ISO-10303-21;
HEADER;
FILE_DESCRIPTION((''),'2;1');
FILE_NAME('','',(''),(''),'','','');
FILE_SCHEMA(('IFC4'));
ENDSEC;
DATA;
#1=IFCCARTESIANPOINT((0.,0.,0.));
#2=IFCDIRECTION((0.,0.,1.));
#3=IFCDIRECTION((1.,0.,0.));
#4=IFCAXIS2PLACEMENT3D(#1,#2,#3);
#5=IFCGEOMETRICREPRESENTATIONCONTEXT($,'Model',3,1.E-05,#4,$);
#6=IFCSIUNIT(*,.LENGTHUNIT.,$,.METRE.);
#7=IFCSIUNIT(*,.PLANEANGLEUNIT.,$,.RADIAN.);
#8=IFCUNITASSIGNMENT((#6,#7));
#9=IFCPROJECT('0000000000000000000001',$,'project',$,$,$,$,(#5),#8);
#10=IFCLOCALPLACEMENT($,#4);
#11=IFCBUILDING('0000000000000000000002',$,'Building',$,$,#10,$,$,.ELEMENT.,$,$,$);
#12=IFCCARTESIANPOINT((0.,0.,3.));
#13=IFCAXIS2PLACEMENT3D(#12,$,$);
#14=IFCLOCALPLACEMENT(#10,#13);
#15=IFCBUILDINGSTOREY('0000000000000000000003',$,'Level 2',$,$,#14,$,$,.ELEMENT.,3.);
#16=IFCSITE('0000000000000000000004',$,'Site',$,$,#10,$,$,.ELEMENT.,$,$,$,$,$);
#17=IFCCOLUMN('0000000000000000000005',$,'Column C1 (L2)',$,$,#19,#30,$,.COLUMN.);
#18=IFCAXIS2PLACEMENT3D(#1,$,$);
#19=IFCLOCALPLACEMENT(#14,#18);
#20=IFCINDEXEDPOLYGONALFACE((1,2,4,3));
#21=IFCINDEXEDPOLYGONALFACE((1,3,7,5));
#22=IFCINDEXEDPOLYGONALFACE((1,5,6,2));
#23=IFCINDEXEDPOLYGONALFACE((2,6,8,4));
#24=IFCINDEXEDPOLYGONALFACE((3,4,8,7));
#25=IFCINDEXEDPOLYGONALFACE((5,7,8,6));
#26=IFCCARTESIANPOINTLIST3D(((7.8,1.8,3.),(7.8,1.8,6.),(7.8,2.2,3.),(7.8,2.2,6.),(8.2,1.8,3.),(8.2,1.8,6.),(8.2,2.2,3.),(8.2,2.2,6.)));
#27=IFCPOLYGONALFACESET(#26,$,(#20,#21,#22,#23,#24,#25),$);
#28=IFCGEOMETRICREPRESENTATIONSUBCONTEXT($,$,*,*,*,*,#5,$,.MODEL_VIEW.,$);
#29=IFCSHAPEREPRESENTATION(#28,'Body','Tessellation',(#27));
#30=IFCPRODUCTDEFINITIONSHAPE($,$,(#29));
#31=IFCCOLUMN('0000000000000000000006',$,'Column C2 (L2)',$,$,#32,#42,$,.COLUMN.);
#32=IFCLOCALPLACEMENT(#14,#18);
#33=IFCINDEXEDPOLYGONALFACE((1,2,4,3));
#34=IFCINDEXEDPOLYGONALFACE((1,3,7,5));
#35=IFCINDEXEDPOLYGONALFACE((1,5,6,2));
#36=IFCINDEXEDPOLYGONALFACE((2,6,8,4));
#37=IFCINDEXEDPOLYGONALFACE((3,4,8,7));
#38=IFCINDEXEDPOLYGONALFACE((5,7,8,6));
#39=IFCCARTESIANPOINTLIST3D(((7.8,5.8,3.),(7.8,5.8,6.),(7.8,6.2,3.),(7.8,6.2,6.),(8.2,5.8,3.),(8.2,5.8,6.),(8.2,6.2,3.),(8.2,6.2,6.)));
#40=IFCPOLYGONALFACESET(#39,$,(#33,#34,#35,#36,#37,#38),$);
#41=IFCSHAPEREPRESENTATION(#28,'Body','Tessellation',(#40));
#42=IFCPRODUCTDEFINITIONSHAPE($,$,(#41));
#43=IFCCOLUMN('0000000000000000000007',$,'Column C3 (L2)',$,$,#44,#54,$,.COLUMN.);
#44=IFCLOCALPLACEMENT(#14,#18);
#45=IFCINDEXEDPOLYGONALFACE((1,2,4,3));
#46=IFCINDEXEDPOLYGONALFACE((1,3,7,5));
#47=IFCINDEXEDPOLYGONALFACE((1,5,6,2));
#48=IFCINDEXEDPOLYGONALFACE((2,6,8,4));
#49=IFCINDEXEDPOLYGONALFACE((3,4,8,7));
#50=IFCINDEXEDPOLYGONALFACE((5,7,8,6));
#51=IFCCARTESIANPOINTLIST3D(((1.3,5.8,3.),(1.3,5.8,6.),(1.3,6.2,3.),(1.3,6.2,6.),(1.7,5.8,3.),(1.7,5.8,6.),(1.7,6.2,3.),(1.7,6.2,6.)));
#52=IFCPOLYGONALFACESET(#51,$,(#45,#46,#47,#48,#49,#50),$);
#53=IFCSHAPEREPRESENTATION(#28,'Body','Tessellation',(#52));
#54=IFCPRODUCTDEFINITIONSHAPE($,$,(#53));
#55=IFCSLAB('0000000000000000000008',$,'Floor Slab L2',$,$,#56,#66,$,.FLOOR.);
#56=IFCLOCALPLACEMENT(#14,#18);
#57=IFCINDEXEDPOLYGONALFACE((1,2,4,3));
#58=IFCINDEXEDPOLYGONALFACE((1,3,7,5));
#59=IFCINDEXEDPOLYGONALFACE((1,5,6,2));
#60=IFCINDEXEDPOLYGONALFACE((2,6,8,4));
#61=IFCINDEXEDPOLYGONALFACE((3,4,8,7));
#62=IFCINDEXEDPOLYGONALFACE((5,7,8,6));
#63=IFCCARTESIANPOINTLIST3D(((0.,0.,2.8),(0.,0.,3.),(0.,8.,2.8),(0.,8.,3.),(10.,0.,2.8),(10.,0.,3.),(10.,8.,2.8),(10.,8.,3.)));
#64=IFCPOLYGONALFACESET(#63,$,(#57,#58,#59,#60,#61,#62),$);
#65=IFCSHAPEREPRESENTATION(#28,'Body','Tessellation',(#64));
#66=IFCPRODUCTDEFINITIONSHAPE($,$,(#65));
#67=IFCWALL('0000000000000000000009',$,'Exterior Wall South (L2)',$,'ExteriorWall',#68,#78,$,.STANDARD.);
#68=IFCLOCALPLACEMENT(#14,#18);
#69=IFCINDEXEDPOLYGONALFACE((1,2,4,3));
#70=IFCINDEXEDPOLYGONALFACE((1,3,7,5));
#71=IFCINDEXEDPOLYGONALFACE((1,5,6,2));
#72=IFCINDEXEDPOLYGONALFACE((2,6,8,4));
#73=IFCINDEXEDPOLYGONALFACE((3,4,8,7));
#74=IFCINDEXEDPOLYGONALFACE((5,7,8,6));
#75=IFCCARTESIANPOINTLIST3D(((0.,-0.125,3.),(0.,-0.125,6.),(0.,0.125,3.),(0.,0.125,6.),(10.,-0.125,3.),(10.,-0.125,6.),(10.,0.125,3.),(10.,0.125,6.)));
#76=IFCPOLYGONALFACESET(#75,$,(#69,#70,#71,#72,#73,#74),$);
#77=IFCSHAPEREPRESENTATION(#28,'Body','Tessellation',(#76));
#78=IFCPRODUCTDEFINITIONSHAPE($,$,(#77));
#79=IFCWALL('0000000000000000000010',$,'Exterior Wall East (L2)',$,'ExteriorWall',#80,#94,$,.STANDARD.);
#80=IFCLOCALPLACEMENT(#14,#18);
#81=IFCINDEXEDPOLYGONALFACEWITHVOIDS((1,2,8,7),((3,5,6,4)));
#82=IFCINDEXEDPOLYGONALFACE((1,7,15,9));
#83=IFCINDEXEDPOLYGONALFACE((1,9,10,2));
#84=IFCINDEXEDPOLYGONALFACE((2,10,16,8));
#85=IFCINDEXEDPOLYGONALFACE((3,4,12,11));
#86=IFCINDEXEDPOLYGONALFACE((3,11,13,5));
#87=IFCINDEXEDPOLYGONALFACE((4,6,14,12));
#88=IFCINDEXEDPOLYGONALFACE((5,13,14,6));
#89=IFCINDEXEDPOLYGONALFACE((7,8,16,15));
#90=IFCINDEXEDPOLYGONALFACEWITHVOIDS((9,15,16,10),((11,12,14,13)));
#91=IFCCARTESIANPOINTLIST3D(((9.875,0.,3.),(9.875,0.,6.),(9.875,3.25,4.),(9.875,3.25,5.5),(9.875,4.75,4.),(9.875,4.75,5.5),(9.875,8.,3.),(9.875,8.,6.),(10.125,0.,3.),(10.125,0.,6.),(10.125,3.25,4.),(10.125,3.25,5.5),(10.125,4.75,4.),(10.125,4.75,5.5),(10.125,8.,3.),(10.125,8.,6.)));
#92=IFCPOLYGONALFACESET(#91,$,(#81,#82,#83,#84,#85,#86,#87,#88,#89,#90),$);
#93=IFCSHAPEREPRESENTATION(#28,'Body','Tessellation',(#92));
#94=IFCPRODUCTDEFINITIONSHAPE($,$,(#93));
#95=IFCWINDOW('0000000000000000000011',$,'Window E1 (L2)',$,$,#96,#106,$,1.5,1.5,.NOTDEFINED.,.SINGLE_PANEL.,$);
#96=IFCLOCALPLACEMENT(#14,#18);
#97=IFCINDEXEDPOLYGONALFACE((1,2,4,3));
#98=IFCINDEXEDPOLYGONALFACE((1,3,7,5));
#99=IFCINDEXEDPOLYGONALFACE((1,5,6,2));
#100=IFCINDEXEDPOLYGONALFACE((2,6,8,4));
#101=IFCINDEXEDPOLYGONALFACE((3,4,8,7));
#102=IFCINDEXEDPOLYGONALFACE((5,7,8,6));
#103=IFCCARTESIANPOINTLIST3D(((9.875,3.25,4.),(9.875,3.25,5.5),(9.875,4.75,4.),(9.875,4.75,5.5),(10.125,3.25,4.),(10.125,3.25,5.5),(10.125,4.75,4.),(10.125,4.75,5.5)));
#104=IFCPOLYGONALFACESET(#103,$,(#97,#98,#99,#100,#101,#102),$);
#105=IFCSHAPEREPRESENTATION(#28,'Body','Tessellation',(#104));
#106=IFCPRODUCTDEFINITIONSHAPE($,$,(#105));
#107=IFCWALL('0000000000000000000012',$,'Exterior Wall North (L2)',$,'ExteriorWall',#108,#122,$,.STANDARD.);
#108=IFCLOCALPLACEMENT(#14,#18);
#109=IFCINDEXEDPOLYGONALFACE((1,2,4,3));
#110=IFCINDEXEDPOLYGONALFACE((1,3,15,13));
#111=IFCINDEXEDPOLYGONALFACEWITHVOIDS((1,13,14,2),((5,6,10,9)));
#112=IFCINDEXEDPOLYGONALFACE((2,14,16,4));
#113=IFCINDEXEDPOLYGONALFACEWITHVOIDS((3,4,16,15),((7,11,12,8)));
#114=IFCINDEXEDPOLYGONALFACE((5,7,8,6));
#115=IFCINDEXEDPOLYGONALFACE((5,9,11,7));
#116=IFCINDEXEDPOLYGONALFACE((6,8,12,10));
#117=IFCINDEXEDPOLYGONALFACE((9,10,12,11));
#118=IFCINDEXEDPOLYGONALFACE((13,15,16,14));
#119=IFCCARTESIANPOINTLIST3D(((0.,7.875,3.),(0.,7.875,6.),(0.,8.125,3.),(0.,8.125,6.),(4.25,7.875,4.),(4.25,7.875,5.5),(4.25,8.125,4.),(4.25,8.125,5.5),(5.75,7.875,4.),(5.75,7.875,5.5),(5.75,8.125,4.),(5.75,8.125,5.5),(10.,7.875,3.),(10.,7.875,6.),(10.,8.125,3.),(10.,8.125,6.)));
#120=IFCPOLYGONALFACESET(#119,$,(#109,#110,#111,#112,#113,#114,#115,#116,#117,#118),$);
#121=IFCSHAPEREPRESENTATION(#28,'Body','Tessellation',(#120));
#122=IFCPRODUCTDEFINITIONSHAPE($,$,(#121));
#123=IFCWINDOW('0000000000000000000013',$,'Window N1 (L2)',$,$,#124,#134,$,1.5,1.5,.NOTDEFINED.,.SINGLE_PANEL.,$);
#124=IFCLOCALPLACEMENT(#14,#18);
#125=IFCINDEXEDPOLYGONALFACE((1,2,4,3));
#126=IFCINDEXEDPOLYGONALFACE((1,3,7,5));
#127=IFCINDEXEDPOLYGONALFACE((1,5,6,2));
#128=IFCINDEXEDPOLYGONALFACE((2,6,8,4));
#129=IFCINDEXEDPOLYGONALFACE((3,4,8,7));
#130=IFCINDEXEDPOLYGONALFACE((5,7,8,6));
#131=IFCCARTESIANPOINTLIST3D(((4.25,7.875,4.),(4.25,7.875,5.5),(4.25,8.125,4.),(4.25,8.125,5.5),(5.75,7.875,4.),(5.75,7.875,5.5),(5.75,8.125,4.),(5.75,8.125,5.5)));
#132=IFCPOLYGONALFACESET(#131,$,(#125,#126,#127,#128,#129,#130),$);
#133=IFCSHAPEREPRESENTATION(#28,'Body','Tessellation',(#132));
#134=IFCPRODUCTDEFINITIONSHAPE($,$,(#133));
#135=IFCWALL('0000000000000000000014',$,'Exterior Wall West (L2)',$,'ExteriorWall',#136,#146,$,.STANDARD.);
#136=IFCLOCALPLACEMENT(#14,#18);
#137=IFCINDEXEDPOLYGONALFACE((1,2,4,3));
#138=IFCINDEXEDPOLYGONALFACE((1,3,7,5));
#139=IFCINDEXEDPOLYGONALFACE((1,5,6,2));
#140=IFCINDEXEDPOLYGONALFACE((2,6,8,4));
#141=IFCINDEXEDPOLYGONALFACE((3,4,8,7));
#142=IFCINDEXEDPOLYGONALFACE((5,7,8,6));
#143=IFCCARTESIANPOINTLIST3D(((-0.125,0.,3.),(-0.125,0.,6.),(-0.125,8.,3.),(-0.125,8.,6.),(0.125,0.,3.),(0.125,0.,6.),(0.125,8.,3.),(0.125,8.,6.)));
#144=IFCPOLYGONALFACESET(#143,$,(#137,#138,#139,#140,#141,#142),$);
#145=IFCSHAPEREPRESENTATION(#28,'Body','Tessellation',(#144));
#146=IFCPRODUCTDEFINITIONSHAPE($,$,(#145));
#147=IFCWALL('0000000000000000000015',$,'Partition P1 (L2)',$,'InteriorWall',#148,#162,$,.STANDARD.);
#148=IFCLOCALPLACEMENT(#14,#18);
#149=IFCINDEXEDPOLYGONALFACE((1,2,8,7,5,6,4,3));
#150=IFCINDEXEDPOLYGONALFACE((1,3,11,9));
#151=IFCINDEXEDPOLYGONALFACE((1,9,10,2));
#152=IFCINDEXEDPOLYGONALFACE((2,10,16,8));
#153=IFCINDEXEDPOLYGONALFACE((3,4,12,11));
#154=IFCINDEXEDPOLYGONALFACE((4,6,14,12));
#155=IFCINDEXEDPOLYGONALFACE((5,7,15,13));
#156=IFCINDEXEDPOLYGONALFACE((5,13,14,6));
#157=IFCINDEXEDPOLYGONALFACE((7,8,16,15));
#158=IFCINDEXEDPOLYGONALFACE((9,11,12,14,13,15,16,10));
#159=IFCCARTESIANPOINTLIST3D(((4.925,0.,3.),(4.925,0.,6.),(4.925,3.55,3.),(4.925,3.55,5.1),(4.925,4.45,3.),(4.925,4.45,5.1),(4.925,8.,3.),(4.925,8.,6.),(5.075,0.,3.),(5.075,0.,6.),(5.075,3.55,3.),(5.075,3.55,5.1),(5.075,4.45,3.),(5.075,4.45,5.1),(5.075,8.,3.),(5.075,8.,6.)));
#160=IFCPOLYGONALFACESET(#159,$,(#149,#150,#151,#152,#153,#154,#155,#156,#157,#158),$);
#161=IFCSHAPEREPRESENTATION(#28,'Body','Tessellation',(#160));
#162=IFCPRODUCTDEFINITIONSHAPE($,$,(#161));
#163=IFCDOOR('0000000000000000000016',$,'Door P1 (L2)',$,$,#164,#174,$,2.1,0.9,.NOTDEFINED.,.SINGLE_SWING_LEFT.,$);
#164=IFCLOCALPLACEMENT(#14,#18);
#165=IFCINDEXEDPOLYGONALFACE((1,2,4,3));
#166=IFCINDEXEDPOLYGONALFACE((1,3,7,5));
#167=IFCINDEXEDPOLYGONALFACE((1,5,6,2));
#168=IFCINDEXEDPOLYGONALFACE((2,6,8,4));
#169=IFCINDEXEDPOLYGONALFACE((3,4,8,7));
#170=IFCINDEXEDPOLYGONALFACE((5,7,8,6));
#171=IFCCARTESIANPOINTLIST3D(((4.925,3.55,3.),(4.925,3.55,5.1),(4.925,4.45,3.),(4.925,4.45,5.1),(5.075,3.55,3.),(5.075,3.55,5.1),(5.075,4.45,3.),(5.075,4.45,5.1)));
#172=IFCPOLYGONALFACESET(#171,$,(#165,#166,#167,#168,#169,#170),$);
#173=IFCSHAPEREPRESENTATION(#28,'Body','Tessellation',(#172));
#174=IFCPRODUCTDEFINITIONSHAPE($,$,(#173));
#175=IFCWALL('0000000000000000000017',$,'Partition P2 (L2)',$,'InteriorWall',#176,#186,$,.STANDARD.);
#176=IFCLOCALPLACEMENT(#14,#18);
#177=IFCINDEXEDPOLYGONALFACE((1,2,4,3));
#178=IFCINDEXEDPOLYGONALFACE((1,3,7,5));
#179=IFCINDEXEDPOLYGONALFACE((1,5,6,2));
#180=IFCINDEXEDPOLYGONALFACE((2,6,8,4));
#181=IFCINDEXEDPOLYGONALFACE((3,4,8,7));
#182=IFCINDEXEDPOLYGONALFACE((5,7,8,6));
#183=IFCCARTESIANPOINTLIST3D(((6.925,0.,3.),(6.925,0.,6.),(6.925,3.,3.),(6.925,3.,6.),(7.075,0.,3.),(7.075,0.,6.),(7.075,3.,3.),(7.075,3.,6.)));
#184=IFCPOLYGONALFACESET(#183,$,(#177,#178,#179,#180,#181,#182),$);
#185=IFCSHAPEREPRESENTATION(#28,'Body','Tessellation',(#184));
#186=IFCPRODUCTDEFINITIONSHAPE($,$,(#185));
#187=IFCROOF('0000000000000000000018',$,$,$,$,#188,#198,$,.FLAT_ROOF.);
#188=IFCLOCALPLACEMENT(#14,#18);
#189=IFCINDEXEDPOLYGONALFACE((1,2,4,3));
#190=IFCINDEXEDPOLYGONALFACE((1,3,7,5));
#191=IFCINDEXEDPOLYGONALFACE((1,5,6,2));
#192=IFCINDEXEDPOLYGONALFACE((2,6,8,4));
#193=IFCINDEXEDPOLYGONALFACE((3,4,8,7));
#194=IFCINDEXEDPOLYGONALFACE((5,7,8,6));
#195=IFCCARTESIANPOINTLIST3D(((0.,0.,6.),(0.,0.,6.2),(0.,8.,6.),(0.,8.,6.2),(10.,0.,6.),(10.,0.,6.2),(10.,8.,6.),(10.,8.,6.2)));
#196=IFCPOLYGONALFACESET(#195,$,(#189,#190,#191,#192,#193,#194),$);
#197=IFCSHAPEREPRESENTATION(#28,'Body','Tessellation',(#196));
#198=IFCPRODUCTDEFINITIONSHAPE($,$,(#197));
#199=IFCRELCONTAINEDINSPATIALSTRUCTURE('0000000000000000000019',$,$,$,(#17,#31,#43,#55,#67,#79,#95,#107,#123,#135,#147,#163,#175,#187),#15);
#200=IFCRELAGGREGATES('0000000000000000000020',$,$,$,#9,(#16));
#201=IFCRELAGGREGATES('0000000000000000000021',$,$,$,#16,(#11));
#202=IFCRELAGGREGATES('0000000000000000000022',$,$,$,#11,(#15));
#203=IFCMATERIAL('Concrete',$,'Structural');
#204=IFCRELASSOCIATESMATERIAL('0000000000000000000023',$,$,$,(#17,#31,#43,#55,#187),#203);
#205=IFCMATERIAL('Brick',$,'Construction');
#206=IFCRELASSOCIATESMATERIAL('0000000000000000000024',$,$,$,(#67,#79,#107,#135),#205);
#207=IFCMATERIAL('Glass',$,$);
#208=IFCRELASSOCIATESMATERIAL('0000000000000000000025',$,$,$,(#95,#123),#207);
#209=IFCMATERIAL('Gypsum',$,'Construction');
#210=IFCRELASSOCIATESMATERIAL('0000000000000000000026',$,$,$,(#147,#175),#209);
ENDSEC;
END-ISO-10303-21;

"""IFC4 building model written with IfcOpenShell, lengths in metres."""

from ifc_helpers import new_model, si_unit, frame, frame_2d, origin, origin_with_axes, origin_2d, place, context, subcontext, project, spatial, rectangle, extrude, material, element, fill, save


model = new_model("IFC4")

# Units and contexts
model_context = context("Model", 3, precision=1e-05, world=origin_with_axes())
sub_context = subcontext(model_context, None, None, "MODEL_VIEW")
ifc_project = project(units=[si_unit("LENGTHUNIT", "METRE"), si_unit("PLANEANGLEUNIT", "RADIAN")], contexts=[model_context])

# Site, building, storey
placement = place(None, origin_with_axes())
site = spatial("IfcSite", under=ifc_project, at=placement, Name="Site", CompositionType="ELEMENT")
building = spatial("IfcBuilding", under=site, at=placement, Name="Building", CompositionType="ELEMENT")
storey_placement = place(placement, frame((0.0, 0.0, 3.0)))
storey = spatial("IfcBuildingStorey", under=building, at=storey_placement, Name="Level 2", CompositionType="ELEMENT", Elevation=3.0)

# Columns
ifc_material_1 = material(Name="Concrete", Category="Structural")
for number, where, name in (
    (1, (8.0, 2.0, 3.0), "Column C1 (L2)"),
    (2, (8.0, 6.0, 3.0), "Column C2 (L2)"),
    (3, (1.5, 6.0, 3.0), "Column C3 (L2)"),
):
    element("IfcColumn", number, at=place(storey_placement, frame(where)), inside=storey, material=ifc_material_1, Name=name, PredefinedType="COLUMN", context=sub_context, shape_type="SweptSolid", body=[
        extrude(rectangle(XDim=0.4, YDim=0.4, at=origin_2d()), origin(), (0.0, 0.0, 1.0), 3.0),
    ])

# Slab
slab_placement = place(storey_placement, frame((0.0, 0.0, 2.8)))
element("IfcSlab", 4, at=slab_placement, inside=storey, material=ifc_material_1, Name="Floor Slab L2", PredefinedType="FLOOR", context=sub_context, shape_type="SweptSolid", body=[
    extrude(rectangle(XDim=10.0, YDim=8.0, at=frame_2d((5.0, 4.0))), origin(), (0.0, 0.0, 1.0), 0.2),
])

# Wall
ifc_material_2 = material(Name="Brick", Category="Construction")
wall_1_placement = place(storey_placement, frame((0.0, 0.0, 3.0), x_axis=(1.0, 0.0, 0.0)))
element("IfcWall", 5, at=wall_1_placement, inside=storey, material=ifc_material_2, Name="Exterior Wall South (L2)", ObjectType="ExteriorWall", PredefinedType="STANDARD", context=sub_context, shape_type="SweptSolid", body=[
    extrude(rectangle(XDim=10.0, YDim=0.25, at=frame_2d((5.0, 0.0))), origin(), (0.0, 0.0, 1.0), 3.0),
])

# Walls, openings, windows
wall_2_placement = place(storey_placement, frame((10.0, 0.0, 3.0), x_axis=(0.0, 1.0, 0.0)))
wall_2 = element("IfcWall", 6, at=wall_2_placement, inside=storey, material=ifc_material_2, Name="Exterior Wall East (L2)", ObjectType="ExteriorWall", PredefinedType="STANDARD", context=sub_context, shape_type="SweptSolid", body=[
    extrude(rectangle(XDim=8.0, YDim=0.25, at=frame_2d((4.0, 0.0))), origin(), (0.0, 0.0, 1.0), 3.0),
])
opening_1_placement = place(wall_2_placement, frame((4.0, 0.175, 1.0), z_axis=(0.0, -1.0, 0.0), x_axis=(1.0, 0.0, 0.0)))
opening_1 = element("IfcOpeningElement", 7, at=opening_1_placement, cuts=wall_2, PredefinedType="OPENING", context=sub_context, shape_type="SweptSolid", body=[
    extrude(rectangle(XDim=1.5, YDim=1.5, at=frame_2d((0.0, 0.75))), origin(), (0.0, 0.0, 1.0), 0.35),
])
ifc_material_3 = material(Name="Glass")
window_1_placement = place(wall_2_placement, frame((4.0, 0.125, 1.0), z_axis=(0.0, -1.0, 0.0), x_axis=(1.0, 0.0, 0.0)))
window_1 = element("IfcWindow", 8, at=window_1_placement, inside=storey, material=ifc_material_3, Name="Window E1 (L2)", OverallHeight=1.5, OverallWidth=1.5, PartitioningType="SINGLE_PANEL", PredefinedType="NOTDEFINED", context=sub_context, shape_type="SweptSolid", body=[
    extrude(rectangle(XDim=1.5, YDim=1.5, at=frame_2d((0.0, 0.75))), origin(), (0.0, 0.0, 1.0), 0.25),
])
fill(opening_1, window_1)
wall_3_placement = place(storey_placement, frame((10.0, 8.0, 3.0), x_axis=(-1.0, 0.0, 0.0)))
wall_3 = element("IfcWall", 9, at=wall_3_placement, inside=storey, material=ifc_material_2, Name="Exterior Wall North (L2)", ObjectType="ExteriorWall", PredefinedType="STANDARD", context=sub_context, shape_type="SweptSolid", body=[
    extrude(rectangle(XDim=10.0, YDim=0.25, at=frame_2d((5.0, 0.0))), origin(), (0.0, 0.0, 1.0), 3.0),
])
opening_2_placement = place(wall_3_placement, frame((5.0, 0.175, 1.0), z_axis=(0.0, -1.0, 0.0), x_axis=(1.0, 0.0, 0.0)))
opening_2 = element("IfcOpeningElement", 10, at=opening_2_placement, cuts=wall_3, PredefinedType="OPENING", context=sub_context, shape_type="SweptSolid", body=[
    extrude(rectangle(XDim=1.5, YDim=1.5, at=frame_2d((0.0, 0.75))), origin(), (0.0, 0.0, 1.0), 0.35),
])
window_2_placement = place(wall_3_placement, frame((5.0, 0.125, 1.0), z_axis=(0.0, -1.0, 0.0), x_axis=(1.0, 0.0, 0.0)))
window_2 = element("IfcWindow", 11, at=window_2_placement, inside=storey, material=ifc_material_3, Name="Window N1 (L2)", OverallHeight=1.5, OverallWidth=1.5, PartitioningType="SINGLE_PANEL", PredefinedType="NOTDEFINED", context=sub_context, shape_type="SweptSolid", body=[
    extrude(rectangle(XDim=1.5, YDim=1.5, at=frame_2d((0.0, 0.75))), origin(), (0.0, 0.0, 1.0), 0.25),
])
fill(opening_2, window_2)

# Wall
wall_4_placement = place(storey_placement, frame((0.0, 8.0, 3.0), x_axis=(0.0, -1.0, 0.0)))
element("IfcWall", 12, at=wall_4_placement, inside=storey, material=ifc_material_2, Name="Exterior Wall West (L2)", ObjectType="ExteriorWall", PredefinedType="STANDARD", context=sub_context, shape_type="SweptSolid", body=[
    extrude(rectangle(XDim=8.0, YDim=0.25, at=frame_2d((4.0, 0.0))), origin(), (0.0, 0.0, 1.0), 3.0),
])

# Wall, opening, door
ifc_material_4 = material(Name="Gypsum", Category="Construction")
wall_5_placement = place(storey_placement, frame((5.0, 0.0, 3.0), x_axis=(0.0, 1.0, 0.0)))
wall_5 = element("IfcWall", 13, at=wall_5_placement, inside=storey, material=ifc_material_4, Name="Partition P1 (L2)", ObjectType="InteriorWall", PredefinedType="STANDARD", context=sub_context, shape_type="SweptSolid", body=[
    extrude(rectangle(XDim=8.0, YDim=0.15, at=frame_2d((4.0, 0.0))), origin(), (0.0, 0.0, 1.0), 3.0),
])
opening_3_placement = place(wall_5_placement, frame((4.0, 0.125, 0.0), z_axis=(0.0, -1.0, 0.0), x_axis=(1.0, 0.0, 0.0)))
opening_3 = element("IfcOpeningElement", 14, at=opening_3_placement, cuts=wall_5, PredefinedType="OPENING", context=sub_context, shape_type="SweptSolid", body=[
    extrude(rectangle(XDim=0.9, YDim=2.1, at=frame_2d((0.0, 1.05))), origin(), (0.0, 0.0, 1.0), 0.25),
])
door_placement = place(wall_5_placement, frame((4.0, 0.075, 0.0), z_axis=(0.0, -1.0, 0.0), x_axis=(1.0, 0.0, 0.0)))
door = element("IfcDoor", 15, at=door_placement, inside=storey, Name="Door P1 (L2)", OperationType="SINGLE_SWING_LEFT", OverallHeight=2.1, OverallWidth=0.9, PredefinedType="NOTDEFINED", context=sub_context, shape_type="SweptSolid", body=[
    extrude(rectangle(XDim=0.9, YDim=2.1, at=frame_2d((0.0, 1.05))), origin(), (0.0, 0.0, 1.0), 0.15),
])
fill(opening_3, door)

# Wall
wall_6_placement = place(storey_placement, frame((7.0, 0.0, 3.0), x_axis=(0.0, 1.0, 0.0)))
element("IfcWall", 16, at=wall_6_placement, inside=storey, material=ifc_material_4, Name="Partition P2 (L2)", ObjectType="InteriorWall", PredefinedType="STANDARD", context=sub_context, shape_type="SweptSolid", body=[
    extrude(rectangle(XDim=3.0, YDim=0.15, at=frame_2d((1.5, 0.0))), origin(), (0.0, 0.0, 1.0), 3.0),
])

# Roof
roof_placement = place(storey_placement, frame((0.0, 0.0, 6.0), z_axis=(0.0, 0.0, 1.0), x_axis=(1.0, 0.0, 0.0)))
element("IfcRoof", 17, at=roof_placement, inside=storey, material=ifc_material_1, PredefinedType="FLAT_ROOF", context=sub_context, shape_type="SweptSolid", body=[
    extrude(rectangle(XDim=10.0, YDim=8.0, at=frame_2d((5.0, 4.0))), origin(), (0.0, 0.0, 1.0), 0.2),
])

save(model, "model.ifc")
